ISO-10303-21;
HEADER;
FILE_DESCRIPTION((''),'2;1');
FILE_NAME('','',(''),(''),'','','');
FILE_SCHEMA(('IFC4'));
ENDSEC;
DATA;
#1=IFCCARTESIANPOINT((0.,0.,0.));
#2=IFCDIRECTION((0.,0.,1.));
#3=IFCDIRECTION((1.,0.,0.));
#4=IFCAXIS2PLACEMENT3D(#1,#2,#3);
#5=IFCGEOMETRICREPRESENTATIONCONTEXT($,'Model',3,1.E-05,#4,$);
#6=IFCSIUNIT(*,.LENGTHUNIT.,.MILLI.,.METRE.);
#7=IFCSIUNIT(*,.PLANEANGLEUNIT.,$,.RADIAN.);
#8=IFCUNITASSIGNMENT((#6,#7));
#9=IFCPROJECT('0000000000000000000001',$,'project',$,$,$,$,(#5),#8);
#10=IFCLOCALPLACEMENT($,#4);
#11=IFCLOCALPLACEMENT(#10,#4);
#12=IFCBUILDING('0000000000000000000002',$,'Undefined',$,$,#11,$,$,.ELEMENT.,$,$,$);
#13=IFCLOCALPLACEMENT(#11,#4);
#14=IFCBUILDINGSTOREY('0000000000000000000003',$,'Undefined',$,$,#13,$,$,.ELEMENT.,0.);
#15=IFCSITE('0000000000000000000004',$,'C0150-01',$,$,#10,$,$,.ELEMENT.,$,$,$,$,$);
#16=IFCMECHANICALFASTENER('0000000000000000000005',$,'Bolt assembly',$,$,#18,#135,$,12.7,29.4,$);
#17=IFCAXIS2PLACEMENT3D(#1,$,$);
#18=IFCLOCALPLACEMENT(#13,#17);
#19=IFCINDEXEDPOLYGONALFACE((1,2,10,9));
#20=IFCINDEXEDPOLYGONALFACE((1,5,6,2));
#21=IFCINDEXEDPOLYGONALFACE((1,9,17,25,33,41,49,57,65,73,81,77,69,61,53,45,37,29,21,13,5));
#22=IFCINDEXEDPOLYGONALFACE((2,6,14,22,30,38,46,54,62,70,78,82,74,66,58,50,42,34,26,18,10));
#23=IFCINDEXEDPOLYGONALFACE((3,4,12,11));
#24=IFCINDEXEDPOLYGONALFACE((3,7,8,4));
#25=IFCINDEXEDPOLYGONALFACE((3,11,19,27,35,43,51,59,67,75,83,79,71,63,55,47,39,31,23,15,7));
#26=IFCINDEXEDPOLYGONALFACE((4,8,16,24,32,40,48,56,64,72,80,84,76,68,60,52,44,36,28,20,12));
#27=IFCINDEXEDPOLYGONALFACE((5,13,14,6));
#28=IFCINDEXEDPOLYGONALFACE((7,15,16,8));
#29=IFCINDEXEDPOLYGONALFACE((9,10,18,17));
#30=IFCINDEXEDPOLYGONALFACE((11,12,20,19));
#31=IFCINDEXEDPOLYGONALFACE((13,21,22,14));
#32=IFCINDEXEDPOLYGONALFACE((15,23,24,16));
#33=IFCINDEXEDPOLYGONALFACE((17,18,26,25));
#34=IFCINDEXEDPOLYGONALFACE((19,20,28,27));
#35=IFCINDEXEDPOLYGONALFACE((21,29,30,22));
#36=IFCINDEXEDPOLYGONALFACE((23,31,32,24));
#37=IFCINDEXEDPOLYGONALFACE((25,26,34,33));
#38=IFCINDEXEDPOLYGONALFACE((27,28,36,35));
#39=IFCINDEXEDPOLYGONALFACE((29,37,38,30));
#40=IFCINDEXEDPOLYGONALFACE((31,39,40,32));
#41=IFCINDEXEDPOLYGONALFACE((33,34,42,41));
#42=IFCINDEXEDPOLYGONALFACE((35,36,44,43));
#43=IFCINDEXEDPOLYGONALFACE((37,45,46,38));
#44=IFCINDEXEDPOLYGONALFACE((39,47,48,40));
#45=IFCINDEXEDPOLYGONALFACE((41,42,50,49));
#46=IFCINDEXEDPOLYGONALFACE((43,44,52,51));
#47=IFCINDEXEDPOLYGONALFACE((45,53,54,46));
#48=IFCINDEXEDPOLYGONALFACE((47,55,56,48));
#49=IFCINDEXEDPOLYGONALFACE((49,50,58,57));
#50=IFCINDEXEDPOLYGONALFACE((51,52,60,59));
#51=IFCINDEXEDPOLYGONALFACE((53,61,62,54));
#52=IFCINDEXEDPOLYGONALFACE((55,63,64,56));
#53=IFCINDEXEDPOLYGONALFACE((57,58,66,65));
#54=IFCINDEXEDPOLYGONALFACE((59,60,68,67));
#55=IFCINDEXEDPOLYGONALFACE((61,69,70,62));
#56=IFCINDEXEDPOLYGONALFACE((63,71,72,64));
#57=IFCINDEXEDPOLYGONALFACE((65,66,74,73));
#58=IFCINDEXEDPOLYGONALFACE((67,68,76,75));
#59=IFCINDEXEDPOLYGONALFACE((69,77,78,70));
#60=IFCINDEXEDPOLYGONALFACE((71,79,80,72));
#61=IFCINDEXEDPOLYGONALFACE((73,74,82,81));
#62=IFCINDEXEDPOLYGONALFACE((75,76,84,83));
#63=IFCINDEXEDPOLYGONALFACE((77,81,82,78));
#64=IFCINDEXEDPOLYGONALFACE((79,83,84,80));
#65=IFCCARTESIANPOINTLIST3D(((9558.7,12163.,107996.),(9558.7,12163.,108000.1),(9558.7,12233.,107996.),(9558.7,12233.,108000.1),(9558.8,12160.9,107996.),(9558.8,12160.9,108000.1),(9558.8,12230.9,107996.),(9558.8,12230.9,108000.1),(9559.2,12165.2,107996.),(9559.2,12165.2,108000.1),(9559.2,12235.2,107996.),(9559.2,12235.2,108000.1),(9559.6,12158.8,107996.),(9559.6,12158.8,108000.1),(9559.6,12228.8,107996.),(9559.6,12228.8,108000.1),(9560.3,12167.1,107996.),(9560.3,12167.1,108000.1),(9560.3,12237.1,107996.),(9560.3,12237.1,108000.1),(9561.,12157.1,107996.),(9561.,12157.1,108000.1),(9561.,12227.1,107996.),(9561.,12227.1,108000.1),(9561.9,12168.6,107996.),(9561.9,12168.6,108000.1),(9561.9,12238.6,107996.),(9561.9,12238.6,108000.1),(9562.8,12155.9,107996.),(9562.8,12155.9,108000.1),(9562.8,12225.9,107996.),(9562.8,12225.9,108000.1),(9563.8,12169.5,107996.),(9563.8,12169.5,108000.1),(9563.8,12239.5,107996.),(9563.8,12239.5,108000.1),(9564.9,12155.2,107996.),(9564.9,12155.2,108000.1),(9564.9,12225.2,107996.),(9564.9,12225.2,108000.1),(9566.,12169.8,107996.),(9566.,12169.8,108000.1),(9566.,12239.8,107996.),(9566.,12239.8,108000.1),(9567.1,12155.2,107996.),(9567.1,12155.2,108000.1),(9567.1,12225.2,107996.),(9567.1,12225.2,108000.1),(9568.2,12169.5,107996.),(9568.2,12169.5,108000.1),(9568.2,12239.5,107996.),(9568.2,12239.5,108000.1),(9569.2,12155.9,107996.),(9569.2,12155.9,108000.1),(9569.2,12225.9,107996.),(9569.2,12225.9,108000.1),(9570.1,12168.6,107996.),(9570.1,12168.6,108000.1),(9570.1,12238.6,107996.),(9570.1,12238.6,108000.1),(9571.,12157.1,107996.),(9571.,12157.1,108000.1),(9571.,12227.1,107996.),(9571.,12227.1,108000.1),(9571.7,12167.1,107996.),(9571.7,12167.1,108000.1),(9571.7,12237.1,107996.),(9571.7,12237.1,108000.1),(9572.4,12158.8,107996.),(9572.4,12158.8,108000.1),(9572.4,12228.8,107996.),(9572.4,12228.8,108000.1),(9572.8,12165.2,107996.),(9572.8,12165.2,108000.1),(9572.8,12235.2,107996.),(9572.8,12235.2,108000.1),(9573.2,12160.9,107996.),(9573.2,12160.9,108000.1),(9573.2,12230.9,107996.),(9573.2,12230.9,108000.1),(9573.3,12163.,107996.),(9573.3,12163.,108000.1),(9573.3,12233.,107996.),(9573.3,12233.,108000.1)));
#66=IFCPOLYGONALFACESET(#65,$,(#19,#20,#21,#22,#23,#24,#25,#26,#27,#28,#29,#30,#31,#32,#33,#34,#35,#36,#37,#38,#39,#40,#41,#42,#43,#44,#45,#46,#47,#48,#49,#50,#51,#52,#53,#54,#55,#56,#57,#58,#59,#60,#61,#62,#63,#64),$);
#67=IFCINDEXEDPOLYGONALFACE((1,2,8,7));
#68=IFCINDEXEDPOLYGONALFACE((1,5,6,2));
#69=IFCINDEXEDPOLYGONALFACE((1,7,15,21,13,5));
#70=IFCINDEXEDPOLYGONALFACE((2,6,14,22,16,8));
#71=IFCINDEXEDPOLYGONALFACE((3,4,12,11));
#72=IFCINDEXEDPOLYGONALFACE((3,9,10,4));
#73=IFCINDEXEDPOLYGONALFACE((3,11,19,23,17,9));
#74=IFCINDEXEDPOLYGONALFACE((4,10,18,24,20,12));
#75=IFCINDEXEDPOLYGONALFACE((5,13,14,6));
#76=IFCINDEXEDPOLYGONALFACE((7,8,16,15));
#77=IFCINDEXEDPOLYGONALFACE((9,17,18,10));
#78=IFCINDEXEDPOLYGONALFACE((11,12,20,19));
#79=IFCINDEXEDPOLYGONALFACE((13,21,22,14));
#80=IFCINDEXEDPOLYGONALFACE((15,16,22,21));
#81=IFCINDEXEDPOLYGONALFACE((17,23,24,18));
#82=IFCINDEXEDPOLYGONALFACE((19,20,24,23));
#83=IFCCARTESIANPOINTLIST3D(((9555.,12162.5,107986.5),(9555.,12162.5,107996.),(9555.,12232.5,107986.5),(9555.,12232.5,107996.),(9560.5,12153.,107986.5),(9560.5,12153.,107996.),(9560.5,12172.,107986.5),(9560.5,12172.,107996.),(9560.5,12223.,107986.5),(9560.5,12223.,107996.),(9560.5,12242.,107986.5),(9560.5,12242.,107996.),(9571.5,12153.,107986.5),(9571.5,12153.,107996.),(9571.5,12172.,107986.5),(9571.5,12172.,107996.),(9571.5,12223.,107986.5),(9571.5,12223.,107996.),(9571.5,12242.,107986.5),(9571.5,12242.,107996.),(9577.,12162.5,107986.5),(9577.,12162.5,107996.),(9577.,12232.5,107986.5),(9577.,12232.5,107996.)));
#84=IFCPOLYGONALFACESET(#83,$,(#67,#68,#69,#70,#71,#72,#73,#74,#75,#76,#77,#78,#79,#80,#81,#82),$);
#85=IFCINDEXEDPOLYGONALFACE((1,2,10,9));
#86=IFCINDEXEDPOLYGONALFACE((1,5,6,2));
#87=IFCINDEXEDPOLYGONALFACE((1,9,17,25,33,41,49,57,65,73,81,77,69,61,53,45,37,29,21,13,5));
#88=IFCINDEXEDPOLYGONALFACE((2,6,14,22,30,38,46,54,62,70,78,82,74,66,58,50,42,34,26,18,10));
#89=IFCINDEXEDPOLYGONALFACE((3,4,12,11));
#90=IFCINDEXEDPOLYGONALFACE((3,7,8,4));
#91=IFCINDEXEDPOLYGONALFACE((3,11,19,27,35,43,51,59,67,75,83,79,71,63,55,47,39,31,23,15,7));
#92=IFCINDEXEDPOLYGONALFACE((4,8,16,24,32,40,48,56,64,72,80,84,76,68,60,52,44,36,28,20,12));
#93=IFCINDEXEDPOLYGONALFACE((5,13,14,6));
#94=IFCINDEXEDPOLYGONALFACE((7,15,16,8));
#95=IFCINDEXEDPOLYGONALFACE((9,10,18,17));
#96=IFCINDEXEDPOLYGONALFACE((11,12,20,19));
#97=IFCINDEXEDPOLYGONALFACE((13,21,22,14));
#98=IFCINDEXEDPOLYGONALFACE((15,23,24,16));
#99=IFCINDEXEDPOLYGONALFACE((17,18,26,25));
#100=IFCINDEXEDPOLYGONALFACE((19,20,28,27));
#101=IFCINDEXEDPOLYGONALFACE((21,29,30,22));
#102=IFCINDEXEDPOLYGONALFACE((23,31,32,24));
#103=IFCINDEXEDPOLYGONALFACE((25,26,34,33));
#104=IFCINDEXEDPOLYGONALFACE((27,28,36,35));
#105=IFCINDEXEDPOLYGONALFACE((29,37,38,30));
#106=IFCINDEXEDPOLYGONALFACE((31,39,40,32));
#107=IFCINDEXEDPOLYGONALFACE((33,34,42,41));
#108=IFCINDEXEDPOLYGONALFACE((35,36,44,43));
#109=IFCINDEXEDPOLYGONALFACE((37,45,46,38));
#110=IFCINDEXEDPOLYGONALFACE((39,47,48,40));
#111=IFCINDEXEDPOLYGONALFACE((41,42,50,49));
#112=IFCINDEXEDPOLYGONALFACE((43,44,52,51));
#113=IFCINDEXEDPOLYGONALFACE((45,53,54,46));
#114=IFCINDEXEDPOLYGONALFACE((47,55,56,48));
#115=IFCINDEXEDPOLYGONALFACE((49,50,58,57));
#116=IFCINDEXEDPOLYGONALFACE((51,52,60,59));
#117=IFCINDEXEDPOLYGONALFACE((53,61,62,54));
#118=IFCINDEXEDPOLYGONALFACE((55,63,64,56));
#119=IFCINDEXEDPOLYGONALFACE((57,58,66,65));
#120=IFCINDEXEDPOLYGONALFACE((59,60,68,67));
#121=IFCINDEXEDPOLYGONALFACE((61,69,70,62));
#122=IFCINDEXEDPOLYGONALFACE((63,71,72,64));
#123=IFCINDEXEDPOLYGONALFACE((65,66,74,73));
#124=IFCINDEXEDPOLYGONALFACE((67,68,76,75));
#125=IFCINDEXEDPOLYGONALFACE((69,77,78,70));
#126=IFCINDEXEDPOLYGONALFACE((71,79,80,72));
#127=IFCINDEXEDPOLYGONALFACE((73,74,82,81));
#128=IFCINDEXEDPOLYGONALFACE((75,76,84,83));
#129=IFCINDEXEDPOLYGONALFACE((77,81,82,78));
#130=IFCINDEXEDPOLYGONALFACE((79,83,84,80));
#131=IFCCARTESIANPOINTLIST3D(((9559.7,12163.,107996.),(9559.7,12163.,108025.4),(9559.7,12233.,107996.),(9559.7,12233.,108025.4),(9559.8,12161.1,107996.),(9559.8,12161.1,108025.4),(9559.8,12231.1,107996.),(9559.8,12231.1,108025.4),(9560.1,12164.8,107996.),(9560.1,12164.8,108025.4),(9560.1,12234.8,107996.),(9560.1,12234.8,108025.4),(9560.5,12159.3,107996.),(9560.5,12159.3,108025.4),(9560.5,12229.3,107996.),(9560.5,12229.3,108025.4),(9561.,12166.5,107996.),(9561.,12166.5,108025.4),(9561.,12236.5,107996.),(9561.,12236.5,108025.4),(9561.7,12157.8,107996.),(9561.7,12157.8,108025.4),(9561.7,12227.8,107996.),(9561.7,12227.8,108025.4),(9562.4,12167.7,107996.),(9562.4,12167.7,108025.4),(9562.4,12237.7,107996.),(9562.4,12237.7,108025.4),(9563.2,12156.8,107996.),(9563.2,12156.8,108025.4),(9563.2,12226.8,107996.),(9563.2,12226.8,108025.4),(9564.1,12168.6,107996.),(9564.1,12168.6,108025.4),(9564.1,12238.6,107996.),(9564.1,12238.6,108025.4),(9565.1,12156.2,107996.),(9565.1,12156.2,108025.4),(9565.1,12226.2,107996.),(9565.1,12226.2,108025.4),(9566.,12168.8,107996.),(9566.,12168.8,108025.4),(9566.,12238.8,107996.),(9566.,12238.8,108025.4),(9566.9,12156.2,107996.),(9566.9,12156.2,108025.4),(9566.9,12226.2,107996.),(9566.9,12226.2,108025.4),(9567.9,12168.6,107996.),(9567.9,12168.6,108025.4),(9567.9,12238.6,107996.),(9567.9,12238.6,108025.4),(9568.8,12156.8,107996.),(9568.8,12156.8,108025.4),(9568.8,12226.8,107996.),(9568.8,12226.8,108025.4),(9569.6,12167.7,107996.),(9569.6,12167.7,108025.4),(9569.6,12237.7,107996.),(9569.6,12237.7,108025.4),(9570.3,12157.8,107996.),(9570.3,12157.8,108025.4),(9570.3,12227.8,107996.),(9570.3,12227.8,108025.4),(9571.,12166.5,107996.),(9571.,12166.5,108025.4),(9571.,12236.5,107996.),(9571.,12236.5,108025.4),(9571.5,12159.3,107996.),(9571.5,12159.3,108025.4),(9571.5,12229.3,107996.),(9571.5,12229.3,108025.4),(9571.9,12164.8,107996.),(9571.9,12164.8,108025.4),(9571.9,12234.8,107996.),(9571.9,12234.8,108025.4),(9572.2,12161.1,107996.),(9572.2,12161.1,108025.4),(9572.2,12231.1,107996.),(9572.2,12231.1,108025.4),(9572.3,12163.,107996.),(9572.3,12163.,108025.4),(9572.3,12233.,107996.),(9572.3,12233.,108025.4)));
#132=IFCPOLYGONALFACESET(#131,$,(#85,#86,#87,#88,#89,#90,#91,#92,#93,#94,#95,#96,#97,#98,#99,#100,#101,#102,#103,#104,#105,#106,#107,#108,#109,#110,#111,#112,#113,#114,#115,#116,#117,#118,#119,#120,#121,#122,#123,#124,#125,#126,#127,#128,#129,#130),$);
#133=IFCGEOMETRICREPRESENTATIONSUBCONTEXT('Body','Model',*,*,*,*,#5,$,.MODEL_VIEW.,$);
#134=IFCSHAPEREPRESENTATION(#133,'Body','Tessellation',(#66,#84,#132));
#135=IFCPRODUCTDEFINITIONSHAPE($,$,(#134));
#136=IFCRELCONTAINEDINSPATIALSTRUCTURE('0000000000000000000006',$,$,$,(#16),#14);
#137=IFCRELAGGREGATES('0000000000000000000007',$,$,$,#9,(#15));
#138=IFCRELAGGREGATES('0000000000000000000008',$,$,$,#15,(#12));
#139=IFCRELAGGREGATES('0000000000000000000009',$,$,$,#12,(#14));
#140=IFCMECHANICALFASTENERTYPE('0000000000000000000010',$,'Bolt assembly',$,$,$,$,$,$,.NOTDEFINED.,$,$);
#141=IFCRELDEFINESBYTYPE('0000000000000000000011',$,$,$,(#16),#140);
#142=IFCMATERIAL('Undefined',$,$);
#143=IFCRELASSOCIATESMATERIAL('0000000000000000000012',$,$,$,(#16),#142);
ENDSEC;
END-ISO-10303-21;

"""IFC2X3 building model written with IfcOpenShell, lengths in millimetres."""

from ifc_helpers import new_model, si_unit, frame, origin_with_axes, origin_2d_with_axis, place, context, subcontext, project, spatial, polyline, circle, outline, extrude, source, transform, mapped, material, type_object, element, save


model = new_model("IFC2X3")

# Units and contexts
model_context = context("Model", 3, precision=1e-05, world=origin_with_axes())
body_context = subcontext(model_context, "Body", "Model", "MODEL_VIEW")
ifc_project = project(units=[si_unit("LENGTHUNIT", "METRE", prefix="MILLI"), si_unit("PLANEANGLEUNIT", "RADIAN")], contexts=[model_context])

# Site, building, storey
site_placement = place(None, origin_with_axes())
site = spatial("IfcSite", under=ifc_project, at=site_placement, Name="C0150-01", CompositionType="ELEMENT")
building_placement = place(site_placement, origin_with_axes())
building = spatial("IfcBuilding", under=site, at=building_placement, Name="Undefined", CompositionType="ELEMENT")
storey_placement = place(building_placement, origin_with_axes())
storey = spatial("IfcBuildingStorey", under=building, at=storey_placement, Name="Undefined", CompositionType="ELEMENT", Elevation=0.0)

# Mechanical fastener
ifc_material_1 = material(Name="Undefined")
mechanical_fastener_type = type_object("IfcMechanicalFastenerType", Name="Bolt assembly")
shared_shape_1 = source(origin_with_axes(), body_context, "Body", "SweptSolid", [
    extrude(circle(Radius=7.3, at=origin_2d_with_axis()), frame((0.0, 0.0, 0.0), z_axis=(0.0, 1.0, 0.0), x_axis=(1.0, 0.0, 0.0)), (0.0, 0.0, 1.0), 4.1),
    extrude(outline(polyline([(9.5, -5.5), (9.5, 5.5), (0.0, 11.0), (-9.5, 5.5), (-9.5, -5.5), (0.0, -11.0), (9.5, -5.5)])), frame((0.0, -9.5, 0.0), z_axis=(0.0, 1.0, 0.0), x_axis=(1.0, 0.0, 0.0)), (0.0, 0.0, 1.0), 9.5),
    extrude(circle(Radius=6.3, at=origin_2d_with_axis()), frame((0.0, 0.0, 0.0), z_axis=(0.0, 1.0, 0.0), x_axis=(1.0, 0.0, 0.0)), (0.0, 0.0, 1.0), 29.4),
])
for number, where, z_axis, x_axis, name in (
    (1, (9566.0, 12162.5, 107996.0), (1.0, 0.0, 0.0), (0.0, 1.0, 0.0), "Bolt assembly"),
):
    element("IfcMechanicalFastener", number, at=place(storey_placement, frame(where, z_axis=z_axis, x_axis=x_axis)), inside=storey, type_object=mechanical_fastener_type, material=ifc_material_1, Name=name, NominalDiameter=12.7, NominalLength=29.4, context=body_context, shape_type="MappedRepresentation", body=[
        mapped(shared_shape_1, transform((0.0, 0.0, 0.0))),
        mapped(shared_shape_1, transform((70.0, 0.0, 0.0))),
    ])

save(model, "model.ifc")
